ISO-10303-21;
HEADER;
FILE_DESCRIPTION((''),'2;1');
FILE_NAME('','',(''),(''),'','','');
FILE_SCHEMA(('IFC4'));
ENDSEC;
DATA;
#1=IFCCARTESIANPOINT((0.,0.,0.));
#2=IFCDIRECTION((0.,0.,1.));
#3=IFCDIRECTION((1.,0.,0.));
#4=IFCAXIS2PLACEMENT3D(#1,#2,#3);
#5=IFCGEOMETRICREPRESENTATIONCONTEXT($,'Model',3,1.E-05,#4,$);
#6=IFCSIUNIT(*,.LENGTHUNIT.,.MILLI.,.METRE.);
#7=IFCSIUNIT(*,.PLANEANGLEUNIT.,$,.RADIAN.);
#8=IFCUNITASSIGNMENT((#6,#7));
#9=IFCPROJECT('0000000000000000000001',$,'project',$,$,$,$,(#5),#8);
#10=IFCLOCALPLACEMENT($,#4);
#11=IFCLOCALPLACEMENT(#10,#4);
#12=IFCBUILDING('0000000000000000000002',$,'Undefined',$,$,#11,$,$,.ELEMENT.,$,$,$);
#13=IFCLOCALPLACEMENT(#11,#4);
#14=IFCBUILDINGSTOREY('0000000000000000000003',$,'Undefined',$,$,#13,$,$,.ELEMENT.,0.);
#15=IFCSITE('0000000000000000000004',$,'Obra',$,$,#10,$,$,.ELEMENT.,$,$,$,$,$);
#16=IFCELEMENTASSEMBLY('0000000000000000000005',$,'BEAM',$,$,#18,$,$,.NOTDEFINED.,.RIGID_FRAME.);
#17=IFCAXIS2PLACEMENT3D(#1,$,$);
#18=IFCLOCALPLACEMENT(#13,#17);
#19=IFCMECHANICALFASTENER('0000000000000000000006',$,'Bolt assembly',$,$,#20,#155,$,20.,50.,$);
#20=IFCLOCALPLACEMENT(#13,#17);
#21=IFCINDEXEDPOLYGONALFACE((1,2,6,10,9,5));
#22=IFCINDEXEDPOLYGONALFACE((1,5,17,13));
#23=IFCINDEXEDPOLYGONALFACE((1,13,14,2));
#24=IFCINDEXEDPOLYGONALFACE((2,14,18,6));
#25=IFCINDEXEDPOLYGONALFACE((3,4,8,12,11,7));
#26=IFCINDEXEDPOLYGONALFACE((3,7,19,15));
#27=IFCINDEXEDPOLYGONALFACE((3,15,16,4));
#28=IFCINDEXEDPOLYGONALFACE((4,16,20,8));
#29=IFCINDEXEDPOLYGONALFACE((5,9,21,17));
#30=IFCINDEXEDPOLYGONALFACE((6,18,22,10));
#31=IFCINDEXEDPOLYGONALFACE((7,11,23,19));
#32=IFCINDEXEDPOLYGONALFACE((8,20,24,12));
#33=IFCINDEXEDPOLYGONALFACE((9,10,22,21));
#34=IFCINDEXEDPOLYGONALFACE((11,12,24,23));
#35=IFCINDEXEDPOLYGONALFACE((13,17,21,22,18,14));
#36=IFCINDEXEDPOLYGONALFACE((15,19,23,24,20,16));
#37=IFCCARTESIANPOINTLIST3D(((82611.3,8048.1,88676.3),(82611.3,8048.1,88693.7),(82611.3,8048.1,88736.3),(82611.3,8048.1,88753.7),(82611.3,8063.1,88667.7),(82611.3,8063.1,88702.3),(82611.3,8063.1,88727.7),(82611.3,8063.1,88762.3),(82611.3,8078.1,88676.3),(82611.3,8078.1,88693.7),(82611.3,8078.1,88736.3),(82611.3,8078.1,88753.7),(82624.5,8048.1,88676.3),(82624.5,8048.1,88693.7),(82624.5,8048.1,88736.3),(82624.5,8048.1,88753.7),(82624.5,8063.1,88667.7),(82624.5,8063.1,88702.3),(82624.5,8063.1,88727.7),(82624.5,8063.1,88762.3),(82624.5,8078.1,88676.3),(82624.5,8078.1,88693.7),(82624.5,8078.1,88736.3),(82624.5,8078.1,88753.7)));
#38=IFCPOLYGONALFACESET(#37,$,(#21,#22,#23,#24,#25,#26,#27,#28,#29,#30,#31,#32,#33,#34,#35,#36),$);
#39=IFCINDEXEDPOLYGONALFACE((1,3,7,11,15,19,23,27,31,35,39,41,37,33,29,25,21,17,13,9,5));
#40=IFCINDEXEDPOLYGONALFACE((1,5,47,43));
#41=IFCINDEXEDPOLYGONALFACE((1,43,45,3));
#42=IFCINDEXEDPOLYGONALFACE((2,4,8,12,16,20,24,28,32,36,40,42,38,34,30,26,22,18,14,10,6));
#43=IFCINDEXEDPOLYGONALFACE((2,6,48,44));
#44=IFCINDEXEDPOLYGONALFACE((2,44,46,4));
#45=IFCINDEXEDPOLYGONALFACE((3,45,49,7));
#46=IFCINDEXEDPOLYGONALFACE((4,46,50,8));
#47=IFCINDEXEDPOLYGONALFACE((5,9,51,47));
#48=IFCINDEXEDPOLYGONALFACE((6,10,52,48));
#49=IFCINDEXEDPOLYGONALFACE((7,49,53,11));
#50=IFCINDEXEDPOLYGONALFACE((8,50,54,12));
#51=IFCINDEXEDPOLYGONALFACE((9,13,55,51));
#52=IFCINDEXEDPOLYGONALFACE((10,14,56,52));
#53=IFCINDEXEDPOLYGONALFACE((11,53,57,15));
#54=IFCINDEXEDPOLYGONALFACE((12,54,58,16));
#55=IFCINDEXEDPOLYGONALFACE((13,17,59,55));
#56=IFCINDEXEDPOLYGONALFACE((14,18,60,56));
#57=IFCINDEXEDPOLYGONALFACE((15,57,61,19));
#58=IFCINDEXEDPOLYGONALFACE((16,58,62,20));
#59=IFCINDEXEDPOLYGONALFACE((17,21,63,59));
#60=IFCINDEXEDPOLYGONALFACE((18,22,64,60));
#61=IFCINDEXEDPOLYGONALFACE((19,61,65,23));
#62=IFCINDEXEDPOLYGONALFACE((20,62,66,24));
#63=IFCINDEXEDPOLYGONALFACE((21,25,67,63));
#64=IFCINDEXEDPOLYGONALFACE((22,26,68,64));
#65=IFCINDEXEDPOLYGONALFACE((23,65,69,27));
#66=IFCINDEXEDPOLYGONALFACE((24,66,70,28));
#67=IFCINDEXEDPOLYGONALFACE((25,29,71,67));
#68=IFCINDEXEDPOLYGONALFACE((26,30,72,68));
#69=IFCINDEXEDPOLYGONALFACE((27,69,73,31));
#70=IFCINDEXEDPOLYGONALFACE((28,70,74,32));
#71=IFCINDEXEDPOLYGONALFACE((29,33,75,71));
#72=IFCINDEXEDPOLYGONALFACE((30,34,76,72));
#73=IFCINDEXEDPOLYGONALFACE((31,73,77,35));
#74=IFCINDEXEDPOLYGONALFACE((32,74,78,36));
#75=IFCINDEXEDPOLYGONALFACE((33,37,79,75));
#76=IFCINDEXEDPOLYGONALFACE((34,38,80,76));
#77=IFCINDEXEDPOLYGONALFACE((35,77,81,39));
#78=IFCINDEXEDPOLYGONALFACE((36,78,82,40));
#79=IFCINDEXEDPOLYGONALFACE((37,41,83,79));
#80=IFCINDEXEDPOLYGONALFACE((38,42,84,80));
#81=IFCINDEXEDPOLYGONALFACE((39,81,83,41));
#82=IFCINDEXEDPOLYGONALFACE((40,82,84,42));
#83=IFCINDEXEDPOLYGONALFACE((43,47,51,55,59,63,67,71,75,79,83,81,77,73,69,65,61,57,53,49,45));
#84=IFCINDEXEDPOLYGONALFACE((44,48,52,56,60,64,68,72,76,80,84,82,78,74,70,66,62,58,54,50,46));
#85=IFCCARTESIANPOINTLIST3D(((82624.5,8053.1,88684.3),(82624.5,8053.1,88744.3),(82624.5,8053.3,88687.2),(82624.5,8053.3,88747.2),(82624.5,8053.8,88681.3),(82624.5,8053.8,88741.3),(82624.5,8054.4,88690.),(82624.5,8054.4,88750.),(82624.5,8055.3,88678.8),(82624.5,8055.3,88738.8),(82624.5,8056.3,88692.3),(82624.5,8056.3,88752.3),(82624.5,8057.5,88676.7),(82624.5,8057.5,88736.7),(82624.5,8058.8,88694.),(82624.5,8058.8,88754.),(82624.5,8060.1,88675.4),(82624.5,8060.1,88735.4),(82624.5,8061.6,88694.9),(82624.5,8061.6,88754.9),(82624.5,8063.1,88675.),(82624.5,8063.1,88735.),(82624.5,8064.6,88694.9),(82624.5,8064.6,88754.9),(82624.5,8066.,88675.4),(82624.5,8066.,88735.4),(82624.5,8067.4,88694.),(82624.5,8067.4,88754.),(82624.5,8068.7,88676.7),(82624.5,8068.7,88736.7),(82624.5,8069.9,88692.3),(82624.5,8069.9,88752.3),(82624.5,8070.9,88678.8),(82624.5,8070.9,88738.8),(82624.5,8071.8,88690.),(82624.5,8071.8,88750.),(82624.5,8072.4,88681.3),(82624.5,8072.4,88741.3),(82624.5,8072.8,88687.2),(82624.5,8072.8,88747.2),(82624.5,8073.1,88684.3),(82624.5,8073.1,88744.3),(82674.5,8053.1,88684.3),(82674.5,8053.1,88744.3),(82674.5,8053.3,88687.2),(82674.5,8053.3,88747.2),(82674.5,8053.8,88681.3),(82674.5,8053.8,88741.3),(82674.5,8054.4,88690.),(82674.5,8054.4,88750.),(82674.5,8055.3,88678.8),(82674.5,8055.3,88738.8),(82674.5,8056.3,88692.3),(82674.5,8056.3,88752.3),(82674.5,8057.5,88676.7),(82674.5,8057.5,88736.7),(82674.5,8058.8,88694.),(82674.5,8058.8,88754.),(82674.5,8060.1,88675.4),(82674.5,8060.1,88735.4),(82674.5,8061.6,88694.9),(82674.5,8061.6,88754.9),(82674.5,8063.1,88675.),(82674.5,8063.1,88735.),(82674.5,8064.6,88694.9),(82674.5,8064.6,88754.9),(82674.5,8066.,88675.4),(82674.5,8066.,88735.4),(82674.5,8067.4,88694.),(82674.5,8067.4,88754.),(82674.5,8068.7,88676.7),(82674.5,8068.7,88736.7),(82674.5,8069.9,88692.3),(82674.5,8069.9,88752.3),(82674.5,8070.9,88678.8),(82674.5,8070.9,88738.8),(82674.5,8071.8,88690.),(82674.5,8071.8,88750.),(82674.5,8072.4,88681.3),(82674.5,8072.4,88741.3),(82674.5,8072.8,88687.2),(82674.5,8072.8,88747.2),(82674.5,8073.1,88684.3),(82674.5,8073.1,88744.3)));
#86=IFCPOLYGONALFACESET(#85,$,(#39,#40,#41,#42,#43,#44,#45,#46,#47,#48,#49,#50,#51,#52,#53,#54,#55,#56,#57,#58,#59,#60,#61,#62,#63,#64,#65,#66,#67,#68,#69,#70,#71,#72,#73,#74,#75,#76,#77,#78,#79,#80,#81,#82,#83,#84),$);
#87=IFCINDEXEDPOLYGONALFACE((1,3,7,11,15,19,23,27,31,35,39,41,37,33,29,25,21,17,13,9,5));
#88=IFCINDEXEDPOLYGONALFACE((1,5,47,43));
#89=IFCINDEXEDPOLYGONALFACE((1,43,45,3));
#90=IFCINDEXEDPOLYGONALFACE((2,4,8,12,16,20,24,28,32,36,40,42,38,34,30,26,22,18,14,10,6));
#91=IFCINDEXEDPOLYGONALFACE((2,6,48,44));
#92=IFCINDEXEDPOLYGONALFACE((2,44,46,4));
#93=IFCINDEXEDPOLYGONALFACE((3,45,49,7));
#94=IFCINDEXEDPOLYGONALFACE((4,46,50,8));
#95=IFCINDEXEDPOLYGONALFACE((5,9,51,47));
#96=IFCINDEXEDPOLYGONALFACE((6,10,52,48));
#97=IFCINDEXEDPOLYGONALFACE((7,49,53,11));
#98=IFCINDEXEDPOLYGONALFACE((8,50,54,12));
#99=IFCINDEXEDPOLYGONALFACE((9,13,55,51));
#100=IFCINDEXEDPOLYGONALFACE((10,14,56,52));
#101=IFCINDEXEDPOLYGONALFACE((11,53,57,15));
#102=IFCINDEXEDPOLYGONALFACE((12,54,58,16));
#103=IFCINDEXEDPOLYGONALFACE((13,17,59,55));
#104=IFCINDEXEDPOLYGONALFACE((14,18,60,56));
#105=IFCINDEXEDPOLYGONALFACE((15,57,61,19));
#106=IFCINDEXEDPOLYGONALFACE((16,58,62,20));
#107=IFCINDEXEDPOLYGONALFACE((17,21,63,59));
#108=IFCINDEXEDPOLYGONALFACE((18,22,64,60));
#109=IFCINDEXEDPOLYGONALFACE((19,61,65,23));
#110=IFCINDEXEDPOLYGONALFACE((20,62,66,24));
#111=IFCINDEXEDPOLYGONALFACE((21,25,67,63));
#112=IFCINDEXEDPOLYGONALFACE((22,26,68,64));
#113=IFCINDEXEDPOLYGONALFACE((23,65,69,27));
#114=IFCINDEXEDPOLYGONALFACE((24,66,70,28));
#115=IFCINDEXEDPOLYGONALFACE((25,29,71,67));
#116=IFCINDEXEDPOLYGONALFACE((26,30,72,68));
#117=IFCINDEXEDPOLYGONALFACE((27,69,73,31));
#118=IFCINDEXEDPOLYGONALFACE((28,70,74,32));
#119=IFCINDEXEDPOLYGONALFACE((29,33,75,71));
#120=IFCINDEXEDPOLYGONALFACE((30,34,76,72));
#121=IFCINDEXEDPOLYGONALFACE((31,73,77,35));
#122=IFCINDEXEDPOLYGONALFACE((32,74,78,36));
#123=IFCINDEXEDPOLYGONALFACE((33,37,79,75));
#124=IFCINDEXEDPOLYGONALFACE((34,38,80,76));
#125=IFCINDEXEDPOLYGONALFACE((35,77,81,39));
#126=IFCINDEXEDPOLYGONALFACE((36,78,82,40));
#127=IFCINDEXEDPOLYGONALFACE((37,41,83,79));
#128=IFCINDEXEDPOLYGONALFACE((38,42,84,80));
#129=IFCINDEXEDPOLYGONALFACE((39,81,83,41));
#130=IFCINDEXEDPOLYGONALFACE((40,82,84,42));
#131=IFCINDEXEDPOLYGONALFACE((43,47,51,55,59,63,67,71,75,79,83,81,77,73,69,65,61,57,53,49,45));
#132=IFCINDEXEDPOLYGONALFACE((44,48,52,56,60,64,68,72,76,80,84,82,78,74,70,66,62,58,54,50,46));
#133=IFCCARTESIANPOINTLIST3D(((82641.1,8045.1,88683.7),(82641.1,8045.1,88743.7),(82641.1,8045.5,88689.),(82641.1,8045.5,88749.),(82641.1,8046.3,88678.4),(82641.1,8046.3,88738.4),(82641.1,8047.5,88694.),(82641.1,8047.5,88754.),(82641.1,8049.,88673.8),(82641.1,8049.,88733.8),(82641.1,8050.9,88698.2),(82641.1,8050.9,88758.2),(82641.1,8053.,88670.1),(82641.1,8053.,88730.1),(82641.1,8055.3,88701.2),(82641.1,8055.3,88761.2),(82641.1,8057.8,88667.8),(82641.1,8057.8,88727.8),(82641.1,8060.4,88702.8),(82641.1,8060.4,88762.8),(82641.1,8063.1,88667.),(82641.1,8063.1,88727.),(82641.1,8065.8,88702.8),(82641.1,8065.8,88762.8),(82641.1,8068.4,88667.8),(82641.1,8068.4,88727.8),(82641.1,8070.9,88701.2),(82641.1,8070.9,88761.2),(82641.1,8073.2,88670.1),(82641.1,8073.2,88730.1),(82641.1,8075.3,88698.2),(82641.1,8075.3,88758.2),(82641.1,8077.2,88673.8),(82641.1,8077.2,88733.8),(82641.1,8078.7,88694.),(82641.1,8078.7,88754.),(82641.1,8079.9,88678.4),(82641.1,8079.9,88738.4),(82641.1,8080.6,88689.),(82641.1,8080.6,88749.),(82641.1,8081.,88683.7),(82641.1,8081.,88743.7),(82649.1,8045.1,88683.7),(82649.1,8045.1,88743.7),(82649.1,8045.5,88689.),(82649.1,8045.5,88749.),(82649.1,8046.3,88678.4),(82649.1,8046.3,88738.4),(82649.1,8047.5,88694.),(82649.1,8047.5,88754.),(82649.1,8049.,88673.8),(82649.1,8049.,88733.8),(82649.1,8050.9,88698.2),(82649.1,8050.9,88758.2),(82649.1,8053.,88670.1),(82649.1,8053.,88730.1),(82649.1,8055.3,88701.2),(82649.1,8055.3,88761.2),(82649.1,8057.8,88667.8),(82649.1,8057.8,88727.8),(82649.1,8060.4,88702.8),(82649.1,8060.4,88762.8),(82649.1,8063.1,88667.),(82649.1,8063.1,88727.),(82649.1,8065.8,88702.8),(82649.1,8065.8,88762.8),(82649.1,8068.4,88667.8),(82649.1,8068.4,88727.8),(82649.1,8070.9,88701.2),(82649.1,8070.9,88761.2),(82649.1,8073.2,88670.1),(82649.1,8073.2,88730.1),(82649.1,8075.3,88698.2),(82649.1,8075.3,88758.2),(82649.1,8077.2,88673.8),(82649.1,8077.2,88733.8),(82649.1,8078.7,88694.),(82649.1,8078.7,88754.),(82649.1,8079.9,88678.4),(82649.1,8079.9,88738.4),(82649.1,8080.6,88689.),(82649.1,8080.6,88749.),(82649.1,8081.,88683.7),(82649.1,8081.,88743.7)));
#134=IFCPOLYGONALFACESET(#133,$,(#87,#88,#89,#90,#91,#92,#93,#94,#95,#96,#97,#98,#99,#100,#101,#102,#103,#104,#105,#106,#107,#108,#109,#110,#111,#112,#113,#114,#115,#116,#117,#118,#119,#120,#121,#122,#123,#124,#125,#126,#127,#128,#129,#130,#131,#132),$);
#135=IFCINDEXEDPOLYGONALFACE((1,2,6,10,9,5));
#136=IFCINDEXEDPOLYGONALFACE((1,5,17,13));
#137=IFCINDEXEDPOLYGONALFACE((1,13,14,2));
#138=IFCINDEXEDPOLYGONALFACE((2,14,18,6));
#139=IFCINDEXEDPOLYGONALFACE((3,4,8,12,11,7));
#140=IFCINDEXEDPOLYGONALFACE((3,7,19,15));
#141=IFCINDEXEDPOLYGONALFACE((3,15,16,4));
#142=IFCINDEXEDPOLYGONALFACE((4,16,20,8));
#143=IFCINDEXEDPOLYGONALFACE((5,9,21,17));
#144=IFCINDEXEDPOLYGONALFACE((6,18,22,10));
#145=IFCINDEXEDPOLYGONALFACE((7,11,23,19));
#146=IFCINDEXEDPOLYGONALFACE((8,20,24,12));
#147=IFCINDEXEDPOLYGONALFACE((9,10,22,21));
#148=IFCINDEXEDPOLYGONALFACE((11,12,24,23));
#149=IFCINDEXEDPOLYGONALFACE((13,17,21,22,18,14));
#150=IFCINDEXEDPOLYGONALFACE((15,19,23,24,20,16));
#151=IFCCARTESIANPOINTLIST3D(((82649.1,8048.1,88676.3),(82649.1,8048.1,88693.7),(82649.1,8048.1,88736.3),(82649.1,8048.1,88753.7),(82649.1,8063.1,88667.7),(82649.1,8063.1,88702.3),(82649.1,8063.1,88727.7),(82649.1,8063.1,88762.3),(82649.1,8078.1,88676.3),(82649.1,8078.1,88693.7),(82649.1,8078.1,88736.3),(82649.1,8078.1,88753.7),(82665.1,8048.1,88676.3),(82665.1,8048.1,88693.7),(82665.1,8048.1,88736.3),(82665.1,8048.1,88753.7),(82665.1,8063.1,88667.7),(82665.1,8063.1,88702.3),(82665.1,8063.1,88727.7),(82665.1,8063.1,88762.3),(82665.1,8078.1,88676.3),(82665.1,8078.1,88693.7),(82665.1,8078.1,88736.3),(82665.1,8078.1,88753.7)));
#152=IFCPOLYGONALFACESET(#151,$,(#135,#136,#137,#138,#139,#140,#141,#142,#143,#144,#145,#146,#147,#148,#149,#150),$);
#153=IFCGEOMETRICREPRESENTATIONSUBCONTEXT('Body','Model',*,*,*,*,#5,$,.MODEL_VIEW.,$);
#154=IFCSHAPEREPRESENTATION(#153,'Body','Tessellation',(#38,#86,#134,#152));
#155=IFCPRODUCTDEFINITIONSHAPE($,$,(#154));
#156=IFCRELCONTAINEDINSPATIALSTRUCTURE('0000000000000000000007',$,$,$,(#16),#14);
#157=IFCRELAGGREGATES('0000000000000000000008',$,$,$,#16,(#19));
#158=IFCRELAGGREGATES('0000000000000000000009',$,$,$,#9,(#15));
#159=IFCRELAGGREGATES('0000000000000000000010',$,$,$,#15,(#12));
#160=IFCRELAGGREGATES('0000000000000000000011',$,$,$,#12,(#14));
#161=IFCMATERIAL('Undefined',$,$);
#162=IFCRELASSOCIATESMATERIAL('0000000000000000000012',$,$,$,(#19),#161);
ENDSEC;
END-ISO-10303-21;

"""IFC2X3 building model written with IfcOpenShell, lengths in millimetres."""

from ifc_helpers import new_model, si_unit, frame, origin_with_axes, origin_2d_with_axis, place, context, subcontext, project, spatial, polyline, circle, outline, extrude, source, transform, mapped, material, element, aggregate, save


model = new_model("IFC2X3")

# Units and contexts
model_context = context("Model", 3, precision=1e-05, world=origin_with_axes())
body_context = subcontext(model_context, "Body", "Model", "MODEL_VIEW")
ifc_project = project(units=[si_unit("LENGTHUNIT", "METRE", prefix="MILLI"), si_unit("PLANEANGLEUNIT", "RADIAN")], contexts=[model_context])

# Site, building, storey
site_placement = place(None, origin_with_axes())
site = spatial("IfcSite", under=ifc_project, at=site_placement, Name="Obra", CompositionType="ELEMENT")
building_placement = place(site_placement, origin_with_axes())
building = spatial("IfcBuilding", under=site, at=building_placement, Name="Undefined", CompositionType="ELEMENT")
storey_placement = place(building_placement, origin_with_axes())
storey = spatial("IfcBuildingStorey", under=building, at=storey_placement, Name="Undefined", CompositionType="ELEMENT", Elevation=0.0)

# Shared definitions
ifc_material_1 = material(Name="Undefined")

# Element assembly, mechanical fastener
shared_shape_1 = source(origin_with_axes(), body_context, "Body", "SweptSolid", [
    extrude(outline(polyline([(17.3, 0.0), (8.7, 15.0), (-8.7, 15.0), (-17.3, 0.0), (-8.7, -15.0), (8.7, -15.0), (17.3, 0.0)])), frame((0.0, -26.5, 0.0), z_axis=(0.0, 1.0, 0.0), x_axis=(1.0, 0.0, 0.0)), (0.0, 0.0, 1.0), 13.2),
    extrude(circle(Radius=10.0, at=origin_2d_with_axis()), frame((0.0, -13.3, 0.0), z_axis=(0.0, 1.0, 0.0), x_axis=(1.0, 0.0, 0.0)), (0.0, 0.0, 1.0), 50.0),
    extrude(circle(Radius=18.0, at=origin_2d_with_axis()), frame((0.0, 3.3, 0.0), z_axis=(0.0, 1.0, 0.0), x_axis=(1.0, 0.0, 0.0)), (0.0, 0.0, 1.0), 8.0),
    extrude(outline(polyline([(17.3, 0.0), (8.7, 15.0), (-8.7, 15.0), (-17.3, 0.0), (-8.7, -15.0), (8.7, -15.0), (17.3, 0.0)])), frame((0.0, 11.3, 0.0), z_axis=(0.0, 1.0, 0.0), x_axis=(1.0, 0.0, 0.0)), (0.0, 0.0, 1.0), 16.0),
])
assembly_1_placement = place(storey_placement, origin_with_axes())
assembly_1 = element("IfcElementAssembly", 1, at=assembly_1_placement, inside=storey, Name="BEAM", AssemblyPlace="NOTDEFINED", PredefinedType="RIGID_FRAME")
mechanical_fastener_1_placement = place(assembly_1_placement, frame((82637.8, 8103.1, 88850.0), z_axis=(0.0, -1.0, 0.0), x_axis=(0.0, 0.0, -1.0)))
mechanical_fastener_1 = element("IfcMechanicalFastener", 2, at=mechanical_fastener_1_placement, material=ifc_material_1, Name="Bolt assembly", NominalDiameter=20.0, NominalLength=50.0, context=body_context, shape_type="MappedRepresentation", body=[
    mapped(shared_shape_1, transform((105.0, 0.0, 40.0))),
    mapped(shared_shape_1, transform((165.0, 0.0, 40.0))),
])
aggregate(assembly_1, [mechanical_fastener_1])

save(model, "model.ifc")
